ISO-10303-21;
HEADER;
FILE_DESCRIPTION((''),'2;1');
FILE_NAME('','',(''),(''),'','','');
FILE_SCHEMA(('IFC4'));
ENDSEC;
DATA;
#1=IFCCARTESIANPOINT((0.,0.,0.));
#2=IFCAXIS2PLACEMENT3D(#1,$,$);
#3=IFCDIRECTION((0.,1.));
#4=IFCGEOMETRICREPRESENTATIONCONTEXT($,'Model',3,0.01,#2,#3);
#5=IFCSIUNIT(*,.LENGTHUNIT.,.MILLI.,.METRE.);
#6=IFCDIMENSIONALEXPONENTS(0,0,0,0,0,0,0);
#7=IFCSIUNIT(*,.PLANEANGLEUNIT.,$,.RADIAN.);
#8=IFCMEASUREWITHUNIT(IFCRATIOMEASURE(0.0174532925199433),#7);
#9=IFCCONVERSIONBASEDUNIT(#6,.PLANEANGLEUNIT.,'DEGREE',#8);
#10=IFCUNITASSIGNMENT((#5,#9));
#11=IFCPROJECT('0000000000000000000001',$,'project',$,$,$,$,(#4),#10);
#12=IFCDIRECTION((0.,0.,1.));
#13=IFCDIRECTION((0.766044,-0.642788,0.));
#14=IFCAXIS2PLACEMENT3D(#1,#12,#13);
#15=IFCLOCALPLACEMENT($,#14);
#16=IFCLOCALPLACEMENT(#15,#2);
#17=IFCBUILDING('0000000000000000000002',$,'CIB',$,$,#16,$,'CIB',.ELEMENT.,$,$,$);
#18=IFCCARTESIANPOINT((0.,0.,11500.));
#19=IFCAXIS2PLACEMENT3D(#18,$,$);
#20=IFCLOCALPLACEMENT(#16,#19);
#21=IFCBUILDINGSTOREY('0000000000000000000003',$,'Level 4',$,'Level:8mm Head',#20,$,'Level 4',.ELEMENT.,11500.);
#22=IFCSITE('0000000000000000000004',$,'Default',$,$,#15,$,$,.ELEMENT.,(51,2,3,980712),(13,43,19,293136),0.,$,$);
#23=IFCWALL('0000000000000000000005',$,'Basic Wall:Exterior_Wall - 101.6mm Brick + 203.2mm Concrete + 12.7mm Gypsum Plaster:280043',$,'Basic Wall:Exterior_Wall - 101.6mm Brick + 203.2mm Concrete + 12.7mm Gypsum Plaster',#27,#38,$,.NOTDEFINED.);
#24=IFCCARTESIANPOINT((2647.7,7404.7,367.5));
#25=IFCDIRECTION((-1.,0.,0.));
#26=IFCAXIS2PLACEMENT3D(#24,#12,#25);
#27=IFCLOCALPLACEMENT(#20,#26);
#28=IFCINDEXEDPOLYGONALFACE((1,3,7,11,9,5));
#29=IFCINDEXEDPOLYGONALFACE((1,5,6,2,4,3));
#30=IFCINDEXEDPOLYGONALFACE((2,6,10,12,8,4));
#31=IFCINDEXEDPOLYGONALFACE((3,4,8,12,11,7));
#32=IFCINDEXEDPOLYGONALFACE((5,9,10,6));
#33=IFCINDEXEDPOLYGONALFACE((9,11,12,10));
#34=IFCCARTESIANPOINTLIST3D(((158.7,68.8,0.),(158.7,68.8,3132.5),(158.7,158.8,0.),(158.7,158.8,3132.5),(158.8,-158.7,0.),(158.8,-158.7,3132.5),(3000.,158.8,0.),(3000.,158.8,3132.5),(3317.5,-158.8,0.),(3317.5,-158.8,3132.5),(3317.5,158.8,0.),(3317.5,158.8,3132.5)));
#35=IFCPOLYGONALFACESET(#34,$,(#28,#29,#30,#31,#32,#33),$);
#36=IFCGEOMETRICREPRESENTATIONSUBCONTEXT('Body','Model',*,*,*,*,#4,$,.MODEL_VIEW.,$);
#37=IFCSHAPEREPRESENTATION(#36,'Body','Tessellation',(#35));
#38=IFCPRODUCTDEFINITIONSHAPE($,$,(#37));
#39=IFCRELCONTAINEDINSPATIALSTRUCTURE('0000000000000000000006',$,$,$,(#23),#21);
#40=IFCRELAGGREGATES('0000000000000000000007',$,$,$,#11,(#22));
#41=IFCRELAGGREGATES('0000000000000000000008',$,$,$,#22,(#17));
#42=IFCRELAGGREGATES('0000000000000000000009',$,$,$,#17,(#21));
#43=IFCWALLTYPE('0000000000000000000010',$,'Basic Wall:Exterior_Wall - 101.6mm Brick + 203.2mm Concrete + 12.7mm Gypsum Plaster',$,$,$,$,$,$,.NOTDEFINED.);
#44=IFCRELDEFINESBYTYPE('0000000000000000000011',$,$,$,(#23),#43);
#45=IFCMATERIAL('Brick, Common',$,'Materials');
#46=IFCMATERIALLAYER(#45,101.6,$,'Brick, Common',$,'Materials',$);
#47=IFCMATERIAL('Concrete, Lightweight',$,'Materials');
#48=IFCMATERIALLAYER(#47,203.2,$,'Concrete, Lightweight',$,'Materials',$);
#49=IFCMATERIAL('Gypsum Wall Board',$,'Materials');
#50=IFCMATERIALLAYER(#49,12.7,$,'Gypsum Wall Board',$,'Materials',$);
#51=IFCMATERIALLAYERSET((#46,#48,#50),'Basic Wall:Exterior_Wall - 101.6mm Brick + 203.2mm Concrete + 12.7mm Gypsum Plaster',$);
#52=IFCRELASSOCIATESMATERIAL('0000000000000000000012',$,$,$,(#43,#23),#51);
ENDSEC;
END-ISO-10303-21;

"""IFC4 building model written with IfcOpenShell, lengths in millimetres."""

from ifc_helpers import new_model, entity, si_unit, converted_unit, direction, frame, origin, place, context, subcontext, project, spatial, indexed_curve, outline, extrude, material, layer, layer_set, type_object, element, save


model = new_model("IFC4")

# Units and contexts
model_context = context("Model", 3, precision=0.01, world=origin(), true_north=direction((0.0, 1.0)))
body_context = subcontext(model_context, "Body", "Model", "MODEL_VIEW")
ifc_project = project(units=[si_unit("LENGTHUNIT", "METRE", prefix="MILLI"), converted_unit("PLANEANGLEUNIT", "DEGREE", entity("IfcRatioMeasure", 0.0174532925199433), si_unit("PLANEANGLEUNIT", "RADIAN"), dimensions=[0, 0, 0, 0, 0, 0, 0])], contexts=[model_context])

# Site, building, storey
site_placement = place(None, frame((0.0, 0.0, 0.0), z_axis=(0.0, 0.0, 1.0), x_axis=(0.766044, -0.642788, 0.0)))
site = spatial("IfcSite", under=ifc_project, at=site_placement, Name="Default", CompositionType="ELEMENT", RefLatitude=(51, 2, 3, 980712), RefLongitude=(13, 43, 19, 293136), RefElevation=0.0)
building_placement = place(site_placement, origin())
building = spatial("IfcBuilding", under=site, at=building_placement, Name="CIB", LongName="CIB", CompositionType="ELEMENT")
storey_placement = place(building_placement, frame((0.0, 0.0, 11500.0)))
storey = spatial("IfcBuildingStorey", under=building, at=storey_placement, Name="Level 4", ObjectType="Level:8mm Head", LongName="Level 4", CompositionType="ELEMENT", Elevation=11500.0)

# Wall
ifc_material_1 = material(Name="Brick, Common", Category="Materials")
ifc_layer_1 = layer(ifc_material_1, 101.6, Name="Brick, Common", Category="Materials")
ifc_material_2 = material(Name="Concrete, Lightweight", Category="Materials")
ifc_layer_2 = layer(ifc_material_2, 203.2, Name="Concrete, Lightweight", Category="Materials")
ifc_material_3 = material(Name="Gypsum Wall Board", Category="Materials")
ifc_layer_3 = layer(ifc_material_3, 12.7, Name="Gypsum Wall Board", Category="Materials")
ifc_layer_set_1 = layer_set([ifc_layer_1, ifc_layer_2, ifc_layer_3], Name="Basic Wall:Exterior_Wall - 101.6mm Brick + 203.2mm Concrete + 12.7mm Gypsum Plaster")
wall_type_1 = type_object("IfcWallType", Name="Basic Wall:Exterior_Wall - 101.6mm Brick + 203.2mm Concrete + 12.7mm Gypsum Plaster", PredefinedType="NOTDEFINED", material=ifc_layer_set_1)
wall_1_placement = place(storey_placement, frame((2647.7, 7404.7, 367.5), z_axis=(0.0, 0.0, 1.0), x_axis=(-1.0, 0.0, 0.0)))
element("IfcWall", 1, at=wall_1_placement, inside=storey, type_object=wall_type_1, material=ifc_layer_set_1, Name="Basic Wall:Exterior_Wall - 101.6mm Brick + 203.2mm Concrete + 12.7mm Gypsum Plaster:280043", ObjectType="Basic Wall:Exterior_Wall - 101.6mm Brick + 203.2mm Concrete + 12.7mm Gypsum Plaster", PredefinedType="NOTDEFINED", context=body_context, shape_type="SweptSolid", body=[
    extrude(outline(indexed_curve([(3317.5, -158.8), (3317.5, 158.8), (3000.0, 158.8), (158.8, 158.8), (158.8, 68.8), (158.8, -158.8), (3317.5, -158.8)], self_intersect=False)), origin(), (0.0, 0.0, 1.0), 3132.5),
])

save(model, "model.ifc")
